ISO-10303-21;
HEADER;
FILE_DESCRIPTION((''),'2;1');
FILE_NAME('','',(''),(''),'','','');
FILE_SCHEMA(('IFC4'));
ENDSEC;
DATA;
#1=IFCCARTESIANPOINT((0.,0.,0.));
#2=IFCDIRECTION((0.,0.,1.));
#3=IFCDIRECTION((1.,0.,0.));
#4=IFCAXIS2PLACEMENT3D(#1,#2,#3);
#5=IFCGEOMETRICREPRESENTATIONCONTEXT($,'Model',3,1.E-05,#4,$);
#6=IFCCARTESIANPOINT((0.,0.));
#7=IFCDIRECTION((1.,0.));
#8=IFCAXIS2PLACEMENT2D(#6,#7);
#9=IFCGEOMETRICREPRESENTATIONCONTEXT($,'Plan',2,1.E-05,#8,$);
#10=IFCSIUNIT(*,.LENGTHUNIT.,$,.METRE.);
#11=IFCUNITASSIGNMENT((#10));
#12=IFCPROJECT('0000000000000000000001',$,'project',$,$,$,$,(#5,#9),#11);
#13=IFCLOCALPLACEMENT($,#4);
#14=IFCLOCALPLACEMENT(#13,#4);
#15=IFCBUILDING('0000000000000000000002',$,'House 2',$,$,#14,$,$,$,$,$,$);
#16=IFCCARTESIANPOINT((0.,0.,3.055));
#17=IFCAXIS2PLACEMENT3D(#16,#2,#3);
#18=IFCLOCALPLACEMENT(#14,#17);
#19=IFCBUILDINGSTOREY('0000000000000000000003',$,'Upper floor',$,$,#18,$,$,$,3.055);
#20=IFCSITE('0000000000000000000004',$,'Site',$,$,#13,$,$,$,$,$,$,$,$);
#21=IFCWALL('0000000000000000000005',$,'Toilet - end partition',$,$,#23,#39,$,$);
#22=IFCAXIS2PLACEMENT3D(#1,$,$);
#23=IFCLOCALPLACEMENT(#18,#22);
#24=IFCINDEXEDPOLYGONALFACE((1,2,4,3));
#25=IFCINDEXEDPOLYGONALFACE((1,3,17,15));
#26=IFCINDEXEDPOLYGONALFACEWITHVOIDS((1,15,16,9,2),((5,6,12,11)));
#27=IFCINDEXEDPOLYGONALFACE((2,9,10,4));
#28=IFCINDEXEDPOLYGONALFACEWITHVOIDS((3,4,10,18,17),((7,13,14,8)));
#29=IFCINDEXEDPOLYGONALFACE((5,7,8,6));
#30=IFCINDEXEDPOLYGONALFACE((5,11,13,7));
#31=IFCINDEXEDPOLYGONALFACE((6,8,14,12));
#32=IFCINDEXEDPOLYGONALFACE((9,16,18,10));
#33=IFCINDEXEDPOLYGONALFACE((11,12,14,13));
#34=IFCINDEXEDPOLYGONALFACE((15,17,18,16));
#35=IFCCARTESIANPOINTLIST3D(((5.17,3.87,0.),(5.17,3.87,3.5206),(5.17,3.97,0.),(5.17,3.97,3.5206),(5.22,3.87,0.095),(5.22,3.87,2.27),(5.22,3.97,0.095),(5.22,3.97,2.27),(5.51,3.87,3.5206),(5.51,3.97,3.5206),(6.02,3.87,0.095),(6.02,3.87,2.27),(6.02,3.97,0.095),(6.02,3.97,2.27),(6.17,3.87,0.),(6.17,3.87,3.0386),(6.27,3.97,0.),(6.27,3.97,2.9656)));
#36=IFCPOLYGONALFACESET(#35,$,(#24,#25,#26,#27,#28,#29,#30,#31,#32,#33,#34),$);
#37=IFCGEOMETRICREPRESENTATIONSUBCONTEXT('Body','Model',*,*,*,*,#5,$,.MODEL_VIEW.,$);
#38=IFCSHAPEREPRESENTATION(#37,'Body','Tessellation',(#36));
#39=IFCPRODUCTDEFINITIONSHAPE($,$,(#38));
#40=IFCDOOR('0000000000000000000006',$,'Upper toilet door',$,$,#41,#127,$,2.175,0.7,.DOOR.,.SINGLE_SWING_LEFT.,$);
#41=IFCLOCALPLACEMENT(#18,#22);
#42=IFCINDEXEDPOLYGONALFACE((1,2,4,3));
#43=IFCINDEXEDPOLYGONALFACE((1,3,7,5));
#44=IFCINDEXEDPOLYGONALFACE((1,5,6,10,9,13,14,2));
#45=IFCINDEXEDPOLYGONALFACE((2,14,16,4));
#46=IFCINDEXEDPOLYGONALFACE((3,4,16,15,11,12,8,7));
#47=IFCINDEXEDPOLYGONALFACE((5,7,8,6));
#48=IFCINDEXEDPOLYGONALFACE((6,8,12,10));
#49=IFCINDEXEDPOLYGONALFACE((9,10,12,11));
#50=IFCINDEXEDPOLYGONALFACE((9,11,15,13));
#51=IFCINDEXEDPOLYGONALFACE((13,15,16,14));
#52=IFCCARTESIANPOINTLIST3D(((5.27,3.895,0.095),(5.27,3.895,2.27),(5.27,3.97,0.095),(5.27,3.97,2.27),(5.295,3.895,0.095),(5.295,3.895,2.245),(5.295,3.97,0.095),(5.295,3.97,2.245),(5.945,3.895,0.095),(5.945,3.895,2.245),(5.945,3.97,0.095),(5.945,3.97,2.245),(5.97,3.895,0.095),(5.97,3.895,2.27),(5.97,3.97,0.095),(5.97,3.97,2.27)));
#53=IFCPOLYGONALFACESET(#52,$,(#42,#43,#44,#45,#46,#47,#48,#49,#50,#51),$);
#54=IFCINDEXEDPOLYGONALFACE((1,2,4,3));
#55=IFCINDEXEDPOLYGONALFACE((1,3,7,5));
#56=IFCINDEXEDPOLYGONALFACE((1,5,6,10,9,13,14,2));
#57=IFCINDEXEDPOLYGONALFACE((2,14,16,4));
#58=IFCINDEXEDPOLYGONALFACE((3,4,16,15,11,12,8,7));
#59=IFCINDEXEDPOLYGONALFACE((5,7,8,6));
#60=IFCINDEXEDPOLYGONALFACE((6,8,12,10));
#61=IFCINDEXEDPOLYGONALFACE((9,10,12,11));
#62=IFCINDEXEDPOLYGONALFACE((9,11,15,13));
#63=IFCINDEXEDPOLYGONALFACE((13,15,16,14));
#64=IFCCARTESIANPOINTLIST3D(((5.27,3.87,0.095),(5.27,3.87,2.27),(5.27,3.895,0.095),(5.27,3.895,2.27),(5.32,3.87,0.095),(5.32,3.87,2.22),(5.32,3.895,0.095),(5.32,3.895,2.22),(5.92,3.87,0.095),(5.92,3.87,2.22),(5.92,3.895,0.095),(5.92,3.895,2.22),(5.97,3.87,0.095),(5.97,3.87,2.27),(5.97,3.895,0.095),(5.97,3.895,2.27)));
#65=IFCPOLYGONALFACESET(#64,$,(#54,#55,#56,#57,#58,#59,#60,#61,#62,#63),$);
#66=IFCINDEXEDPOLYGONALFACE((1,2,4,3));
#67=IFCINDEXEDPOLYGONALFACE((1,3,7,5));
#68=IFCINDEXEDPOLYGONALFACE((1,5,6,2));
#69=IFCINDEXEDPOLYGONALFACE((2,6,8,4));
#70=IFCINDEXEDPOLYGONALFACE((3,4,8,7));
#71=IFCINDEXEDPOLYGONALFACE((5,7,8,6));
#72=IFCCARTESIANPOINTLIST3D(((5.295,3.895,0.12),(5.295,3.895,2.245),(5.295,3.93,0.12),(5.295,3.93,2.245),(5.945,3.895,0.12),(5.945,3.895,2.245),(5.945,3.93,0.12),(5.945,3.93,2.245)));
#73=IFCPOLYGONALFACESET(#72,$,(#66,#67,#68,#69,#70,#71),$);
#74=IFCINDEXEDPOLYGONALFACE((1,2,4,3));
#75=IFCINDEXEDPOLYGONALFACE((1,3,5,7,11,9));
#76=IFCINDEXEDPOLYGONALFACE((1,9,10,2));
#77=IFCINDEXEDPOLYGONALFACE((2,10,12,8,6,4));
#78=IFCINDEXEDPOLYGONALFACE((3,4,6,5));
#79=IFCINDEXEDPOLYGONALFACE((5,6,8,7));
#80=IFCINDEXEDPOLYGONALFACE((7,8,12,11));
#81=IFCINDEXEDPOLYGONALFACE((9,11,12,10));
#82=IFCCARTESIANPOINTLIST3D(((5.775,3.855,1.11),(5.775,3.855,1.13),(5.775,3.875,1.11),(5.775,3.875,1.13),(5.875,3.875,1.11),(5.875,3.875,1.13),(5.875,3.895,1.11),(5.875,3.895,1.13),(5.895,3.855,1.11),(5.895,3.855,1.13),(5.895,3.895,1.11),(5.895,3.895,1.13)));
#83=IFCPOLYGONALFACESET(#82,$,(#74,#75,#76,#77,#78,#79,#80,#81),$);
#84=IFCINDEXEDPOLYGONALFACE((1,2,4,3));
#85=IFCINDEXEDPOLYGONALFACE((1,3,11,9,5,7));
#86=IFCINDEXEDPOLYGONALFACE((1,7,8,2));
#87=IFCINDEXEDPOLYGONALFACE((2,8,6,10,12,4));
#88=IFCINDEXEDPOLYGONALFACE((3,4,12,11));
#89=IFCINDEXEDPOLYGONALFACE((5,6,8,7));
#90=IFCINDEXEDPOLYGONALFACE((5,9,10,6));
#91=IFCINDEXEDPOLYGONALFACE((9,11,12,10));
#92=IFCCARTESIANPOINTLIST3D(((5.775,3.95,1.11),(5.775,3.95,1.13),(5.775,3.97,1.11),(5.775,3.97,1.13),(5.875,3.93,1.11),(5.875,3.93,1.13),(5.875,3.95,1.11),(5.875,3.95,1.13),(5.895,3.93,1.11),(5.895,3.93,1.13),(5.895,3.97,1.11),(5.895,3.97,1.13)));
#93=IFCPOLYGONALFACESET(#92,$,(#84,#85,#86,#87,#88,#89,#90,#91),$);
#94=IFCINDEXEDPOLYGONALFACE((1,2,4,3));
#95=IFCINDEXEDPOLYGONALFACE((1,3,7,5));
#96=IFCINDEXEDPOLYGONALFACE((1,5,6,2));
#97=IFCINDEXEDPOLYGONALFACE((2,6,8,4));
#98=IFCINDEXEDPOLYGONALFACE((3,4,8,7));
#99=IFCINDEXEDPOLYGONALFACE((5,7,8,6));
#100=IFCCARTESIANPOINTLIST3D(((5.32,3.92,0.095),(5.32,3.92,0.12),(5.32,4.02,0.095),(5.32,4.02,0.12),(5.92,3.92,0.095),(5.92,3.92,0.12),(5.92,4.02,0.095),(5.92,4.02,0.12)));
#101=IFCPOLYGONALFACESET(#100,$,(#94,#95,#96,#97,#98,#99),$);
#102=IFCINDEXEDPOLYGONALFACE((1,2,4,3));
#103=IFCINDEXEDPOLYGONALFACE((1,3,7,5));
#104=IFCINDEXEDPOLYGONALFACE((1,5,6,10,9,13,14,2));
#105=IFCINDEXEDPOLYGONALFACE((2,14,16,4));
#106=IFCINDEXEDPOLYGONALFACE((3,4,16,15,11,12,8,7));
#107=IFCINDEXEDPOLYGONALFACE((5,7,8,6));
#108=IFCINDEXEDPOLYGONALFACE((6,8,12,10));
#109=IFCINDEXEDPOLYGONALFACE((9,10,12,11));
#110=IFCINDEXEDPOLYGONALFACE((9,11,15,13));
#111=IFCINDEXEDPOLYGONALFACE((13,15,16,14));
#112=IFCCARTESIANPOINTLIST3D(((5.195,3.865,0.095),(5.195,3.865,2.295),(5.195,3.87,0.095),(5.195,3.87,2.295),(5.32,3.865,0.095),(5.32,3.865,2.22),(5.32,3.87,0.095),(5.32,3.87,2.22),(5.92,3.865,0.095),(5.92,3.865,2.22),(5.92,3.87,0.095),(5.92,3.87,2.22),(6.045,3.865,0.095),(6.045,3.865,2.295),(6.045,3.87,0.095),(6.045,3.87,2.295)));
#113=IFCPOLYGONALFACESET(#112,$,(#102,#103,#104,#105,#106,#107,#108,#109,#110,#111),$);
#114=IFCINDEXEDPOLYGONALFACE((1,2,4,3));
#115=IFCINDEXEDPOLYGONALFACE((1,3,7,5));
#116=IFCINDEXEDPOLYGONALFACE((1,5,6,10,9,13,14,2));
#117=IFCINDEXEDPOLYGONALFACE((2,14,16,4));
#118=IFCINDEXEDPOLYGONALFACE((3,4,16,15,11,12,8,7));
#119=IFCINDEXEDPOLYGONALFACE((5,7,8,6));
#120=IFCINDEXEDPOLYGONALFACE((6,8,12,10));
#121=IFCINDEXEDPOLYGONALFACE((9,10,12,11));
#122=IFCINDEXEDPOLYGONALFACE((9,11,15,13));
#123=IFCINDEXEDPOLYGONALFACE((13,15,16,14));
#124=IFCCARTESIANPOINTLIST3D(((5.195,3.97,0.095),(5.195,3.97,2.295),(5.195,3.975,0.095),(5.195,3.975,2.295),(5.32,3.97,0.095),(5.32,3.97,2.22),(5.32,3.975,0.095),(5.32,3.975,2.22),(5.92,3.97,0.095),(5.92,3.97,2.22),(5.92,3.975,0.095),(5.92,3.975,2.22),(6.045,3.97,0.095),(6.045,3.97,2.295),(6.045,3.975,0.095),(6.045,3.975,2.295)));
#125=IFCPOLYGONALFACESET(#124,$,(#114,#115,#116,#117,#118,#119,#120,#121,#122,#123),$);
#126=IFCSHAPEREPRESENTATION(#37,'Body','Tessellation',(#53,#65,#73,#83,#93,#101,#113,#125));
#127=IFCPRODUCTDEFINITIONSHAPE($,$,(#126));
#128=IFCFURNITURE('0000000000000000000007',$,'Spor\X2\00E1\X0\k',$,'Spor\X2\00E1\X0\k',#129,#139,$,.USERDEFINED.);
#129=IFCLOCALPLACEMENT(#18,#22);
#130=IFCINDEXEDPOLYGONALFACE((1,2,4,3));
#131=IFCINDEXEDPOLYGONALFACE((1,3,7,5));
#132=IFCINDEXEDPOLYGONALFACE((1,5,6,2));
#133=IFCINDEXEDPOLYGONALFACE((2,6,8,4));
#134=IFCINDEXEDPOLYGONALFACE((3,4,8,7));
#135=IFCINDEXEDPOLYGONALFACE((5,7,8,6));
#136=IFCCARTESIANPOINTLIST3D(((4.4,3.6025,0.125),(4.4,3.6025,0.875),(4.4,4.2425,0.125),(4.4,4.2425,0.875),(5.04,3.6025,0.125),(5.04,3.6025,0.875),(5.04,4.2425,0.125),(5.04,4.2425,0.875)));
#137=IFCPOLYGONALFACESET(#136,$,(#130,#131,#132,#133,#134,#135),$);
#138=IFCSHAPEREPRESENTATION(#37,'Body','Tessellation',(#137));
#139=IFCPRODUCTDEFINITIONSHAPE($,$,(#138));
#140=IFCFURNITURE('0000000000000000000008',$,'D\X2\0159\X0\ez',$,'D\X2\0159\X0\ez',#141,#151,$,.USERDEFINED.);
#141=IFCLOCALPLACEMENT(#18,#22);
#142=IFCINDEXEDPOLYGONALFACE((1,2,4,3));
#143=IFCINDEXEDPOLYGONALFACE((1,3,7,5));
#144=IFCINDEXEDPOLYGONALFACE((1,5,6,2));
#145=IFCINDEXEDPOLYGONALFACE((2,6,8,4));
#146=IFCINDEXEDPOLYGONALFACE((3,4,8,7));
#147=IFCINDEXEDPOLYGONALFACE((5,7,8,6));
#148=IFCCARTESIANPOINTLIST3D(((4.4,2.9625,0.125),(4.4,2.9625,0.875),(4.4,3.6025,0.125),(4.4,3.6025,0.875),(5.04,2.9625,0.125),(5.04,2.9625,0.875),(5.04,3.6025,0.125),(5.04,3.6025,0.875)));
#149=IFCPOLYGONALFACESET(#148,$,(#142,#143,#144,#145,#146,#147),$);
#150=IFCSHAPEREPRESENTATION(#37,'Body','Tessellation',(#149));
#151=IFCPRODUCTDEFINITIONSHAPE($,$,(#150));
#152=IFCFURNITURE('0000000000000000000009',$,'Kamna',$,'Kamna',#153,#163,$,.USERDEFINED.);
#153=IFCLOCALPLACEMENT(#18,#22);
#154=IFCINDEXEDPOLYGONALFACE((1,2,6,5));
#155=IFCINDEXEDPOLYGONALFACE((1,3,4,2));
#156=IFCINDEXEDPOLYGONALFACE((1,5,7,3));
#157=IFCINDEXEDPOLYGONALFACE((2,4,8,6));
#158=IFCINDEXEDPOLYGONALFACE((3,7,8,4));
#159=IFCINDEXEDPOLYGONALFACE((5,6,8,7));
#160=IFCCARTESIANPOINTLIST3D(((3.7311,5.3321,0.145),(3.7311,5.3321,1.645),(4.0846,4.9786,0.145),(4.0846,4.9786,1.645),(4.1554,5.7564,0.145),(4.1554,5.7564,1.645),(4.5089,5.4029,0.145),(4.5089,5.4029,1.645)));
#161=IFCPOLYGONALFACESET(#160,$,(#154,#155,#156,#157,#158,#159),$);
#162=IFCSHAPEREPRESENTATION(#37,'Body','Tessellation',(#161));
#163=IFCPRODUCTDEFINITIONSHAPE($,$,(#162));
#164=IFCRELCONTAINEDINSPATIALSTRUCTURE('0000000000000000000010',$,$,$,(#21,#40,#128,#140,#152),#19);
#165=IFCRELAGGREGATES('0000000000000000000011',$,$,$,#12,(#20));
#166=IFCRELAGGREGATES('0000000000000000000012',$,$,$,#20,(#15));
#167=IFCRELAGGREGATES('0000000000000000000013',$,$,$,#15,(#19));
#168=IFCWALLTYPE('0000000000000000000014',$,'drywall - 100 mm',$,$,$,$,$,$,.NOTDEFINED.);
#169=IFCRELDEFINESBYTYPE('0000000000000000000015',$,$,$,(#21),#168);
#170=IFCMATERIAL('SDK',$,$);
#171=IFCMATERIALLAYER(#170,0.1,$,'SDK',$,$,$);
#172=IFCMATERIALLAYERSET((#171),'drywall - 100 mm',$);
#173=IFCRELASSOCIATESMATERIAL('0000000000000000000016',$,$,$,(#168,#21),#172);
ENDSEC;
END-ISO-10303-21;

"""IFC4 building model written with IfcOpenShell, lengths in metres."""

from ifc_helpers import new_model, entity, si_unit, frame, origin_with_axes, origin_2d_with_axis, place, context, subcontext, project, spatial, line, indexed_curve, outline, extrude, clip, halfspace, shape, source, transform, mapped, material, layer, layer_set, layer_usage, type_object, element, fill, save


model = new_model("IFC4")

# Units and contexts
model_context = context("Model", 3, precision=1e-05, world=origin_with_axes())
plan_context = context("Plan", 2, precision=1e-05, world=origin_2d_with_axis())
body_context_1 = subcontext(model_context, "Body", "Model", "MODEL_VIEW")
body_context_2 = subcontext(plan_context, "Body", "Plan", "PLAN_VIEW")
ifc_project = project(units=[si_unit("LENGTHUNIT", "METRE")], contexts=[model_context, plan_context])

# Site, building, storey
site_placement = place(None, origin_with_axes())
site = spatial("IfcSite", under=ifc_project, at=site_placement, Name="Site")
building_placement = place(site_placement, origin_with_axes())
building = spatial("IfcBuilding", under=site, at=building_placement, Name="House 2")
storey_placement = place(building_placement, frame((0.0, 0.0, 3.055), z_axis=(0.0, 0.0, 1.0), x_axis=(1.0, 0.0, 0.0)))
storey = spatial("IfcBuildingStorey", under=building, at=storey_placement, Name="Upper floor", Elevation=3.055)

# Shared definitions
ifc_material_1 = material(Name="SDK")
ifc_layer = layer(ifc_material_1, 0.1, Name="SDK")
ifc_layer_set = layer_set([ifc_layer], Name="drywall - 100 mm")
wall_type = type_object("IfcWallType", Name="drywall - 100 mm", PredefinedType="NOTDEFINED", material=ifc_layer_set)

# Wall, opening, door
ifc_layer_usage_1 = layer_usage(ifc_layer_set, "AXIS2", "NEGATIVE", 0.05)
wall_1_placement = place(storey_placement, frame((5.17, 3.92, 0.0), z_axis=(0.0, 0.0, 1.0), x_axis=(1.0, 0.0, 0.0)))
wall_1 = element("IfcWall", 1, at=wall_1_placement, inside=storey, type_object=wall_type, material=ifc_layer_usage_1, Name="Toilet - end partition", context=body_context_1, shape_type="Clipping", body=[
    clip(clip(clip(extrude(outline(indexed_curve([(0.0, -0.05), (0.0, 0.05), (1.1, 0.05), (1.0, -0.05)], segments=[line(1, 2, 3, 4, 1)])), origin_with_axes(), (0.0, 0.0, 1.0), 4.9457), halfspace(frame((-4.9413, -3.92, 1.3216), z_axis=(-0.58975, 0.0, 0.807586), x_axis=(0.0, 1.0, 0.0)), False)), halfspace(frame((3.3513, -3.92, 1.3216), z_axis=(0.58975, 0.0, 0.807586), x_axis=(0.0, -1.0, 0.0)), False)), halfspace(frame((-5.17, -3.92, 3.5206), z_axis=(0.0, 0.0, 1.0), x_axis=(-1.0, 0.0, 0.0)), False)),
])
opening_1_placement = place(wall_1_placement, frame((0.05, 0.0, 0.095), z_axis=(0.0, 0.0, 1.0), x_axis=(1.0, 0.0, 0.0)))
opening_1 = element("IfcOpeningElement", 2, at=opening_1_placement, cuts=wall_1, PredefinedType="OPENING", context=body_context_1, shape_type="SweptSolid", body=[
    extrude(outline(indexed_curve([(0.0, 0.0), (0.0, 0.2), (0.8, 0.2), (0.8, 0.0), (0.0, 0.0)], self_intersect=False)), frame((0.0, -0.1, 0.0), z_axis=(0.0, 0.0, 1.0), x_axis=(1.0, 0.0, 0.0)), (0.0, 0.0, 1.0), 2.175),
])
shared_indexed_poly_curve = entity("IfcIndexedPolyCurve", entity("IfcCartesianPointList2D", [[-0.075, 0.0], [-0.075, 2.2], [0.775, 2.2], [0.775, 0.0], [0.65, 0.0], [0.65, 2.125], [0.05, 2.125], [0.05, 0.0]]), [entity("IfcLineIndex", [1, 2, 3, 4, 5, 6, 7, 8, 1])])
shared_shape = source(origin_with_axes(), body_context_2, "Body", "Curve2D", [
    entity("IfcIndexedPolyCurve", entity("IfcCartesianPointList2D", [[0.0, -0.05], [0.0, 0.05], [0.025, 0.05], [0.025, -0.025], [0.05, -0.025], [0.05, -0.05]]), [entity("IfcLineIndex", [1, 2, 3, 4, 5, 6, 1])]),
    entity("IfcIndexedPolyCurve", entity("IfcCartesianPointList2D", [[0.7, -0.05], [0.7, 0.05], [0.675, 0.05], [0.675, -0.025], [0.65, -0.025], [0.65, -0.05]]), [entity("IfcLineIndex", [1, 2, 3, 4, 5, 6, 1])]),
    entity("IfcTrimmedCurve", entity("IfcEllipse", entity("IfcAxis2Placement2D", entity("IfcCartesianPoint", [0.06, 0.05]), entity("IfcDirection", [1.0, 0.0])), 0.615, 0.65), [entity("IfcCartesianPoint", [0.675, 0.05])], [entity("IfcCartesianPoint", [0.06, 0.7])], True, "CARTESIAN"),
    entity("IfcIndexedPolyCurve", entity("IfcCartesianPointList2D", [[0.025, 0.05], [0.06, 0.05], [0.06, 0.7], [0.025, 0.7]]), [entity("IfcLineIndex", [1, 2, 3, 4, 1])]),
])
door_placement = place(opening_1_placement, frame((0.05, 0.0, 0.0), z_axis=(0.0, 0.0, 1.0), x_axis=(1.0, 0.0, 0.0)))
door = element("IfcDoor", 3, at=door_placement, inside=storey, Name="Upper toilet door", OperationType="SINGLE_SWING_LEFT", OverallHeight=2.175, OverallWidth=0.7, PredefinedType="DOOR", shapes=[
    shape(body_context_1, "Body", "SweptSolid", [extrude(outline(indexed_curve([(0.0, 0.0), (0.0, 2.175), (0.7, 2.175), (0.7, 0.0), (0.675, 0.0), (0.675, 2.15), (0.025, 2.15), (0.025, 0.0)], segments=[line(1, 2, 3, 4, 5, 6, 7, 8, 1)])), frame((0.0, -0.025, 0.0), z_axis=(0.0, -1.0, 0.0), x_axis=(1.0, 0.0, 0.0)), (0.0, 0.0, -1.0), 0.075), extrude(outline(indexed_curve([(0.0, 0.0), (0.0, 2.175), (0.7, 2.175), (0.7, 0.0), (0.65, 0.0), (0.65, 2.125), (0.05, 2.125), (0.05, 0.0)], segments=[line(1, 2, 3, 4, 5, 6, 7, 8, 1)])), frame((0.0, -0.05, 0.0), z_axis=(0.0, -1.0, 0.0), x_axis=(1.0, 0.0, 0.0)), (0.0, 0.0, -1.0), 0.025), extrude(outline(indexed_curve([(0.0, 0.0), (0.65, 0.0), (0.65, 0.035), (0.0, 0.035)], segments=[line(1, 2, 3, 4, 1)])), frame((0.025, -0.025, 0.025), z_axis=(0.0, 0.0, 1.0), x_axis=(1.0, 0.0, 0.0)), (0.0, 0.0, 1.0), 2.125), extrude(outline(indexed_curve([(0.0, 0.0), (0.0, -0.04), (-0.12, -0.04), (-0.12, -0.02), (-0.02, -0.02), (-0.02, 0.0)], segments=[line(1, 2, 3, 4, 5, 6, 1)])), frame((0.625, -0.025, 1.015), z_axis=(0.0, 0.0, 1.0), x_axis=(1.0, 0.0, 0.0)), (0.0, 0.0, 1.0), 0.02), extrude(outline(indexed_curve([(0.0, 0.0), (0.0, 0.04), (-0.12, 0.04), (-0.12, 0.02), (-0.02, 0.02), (-0.02, 0.0)], segments=[line(1, 2, 3, 4, 5, 6, 1)])), frame((0.625, 0.01, 1.015), z_axis=(0.0, 0.0, 1.0), x_axis=(1.0, 0.0, 0.0)), (0.0, 0.0, 1.0), 0.02), extrude(outline(indexed_curve([(0.0, 0.0), (0.6, 0.0), (0.6, 0.1), (0.0, 0.1)], segments=[line(1, 2, 3, 4, 1)])), frame((0.05, 0.0, 0.0), z_axis=(0.0, 0.0, 1.0), x_axis=(1.0, 0.0, 0.0)), (0.0, 0.0, 1.0), 0.025), entity("IfcExtrudedAreaSolid", entity("IfcArbitraryClosedProfileDef", "AREA", None, shared_indexed_poly_curve), entity("IfcAxis2Placement3D", entity("IfcCartesianPoint", [0.0, -0.055, 0.0]), entity("IfcDirection", [0.0, -1.0, 0.0]), entity("IfcDirection", [1.0, 0.0, 0.0])), entity("IfcDirection", [0.0, 0.0, -1.0]), 0.005), entity("IfcExtrudedAreaSolid", entity("IfcArbitraryClosedProfileDef", "AREA", None, shared_indexed_poly_curve), entity("IfcAxis2Placement3D", entity("IfcCartesianPoint", [0.0, 0.05, 0.0]), entity("IfcDirection", [0.0, -1.0, 0.0]), entity("IfcDirection", [1.0, 0.0, 0.0])), entity("IfcDirection", [0.0, 0.0, -1.0]), 0.005)]),
    shape(body_context_2, "Body", "MappedRepresentation", [mapped(shared_shape, transform((0.0, 0.0, 1.0875), x_axis=(1.0, 0.0, 0.0), y_axis=(0.0, 1.0, 0.0), z_axis=(0.0, 0.0, 1.0), scale=1.0))]),
])
fill(opening_1, door)

# Furniture
furniture_1_placement = place(storey_placement, frame((4.72, 3.9225, 0.125), z_axis=(0.0, 0.0, 1.0), x_axis=(1.0, 0.0, 0.0)))
element("IfcFurniture", 4, at=furniture_1_placement, inside=storey, Name="Sporák", ObjectType="Sporák", PredefinedType="USERDEFINED", shapes=[
    shape(body_context_1, "Body", "SweptSolid", [extrude(outline(indexed_curve([(-0.32, -0.32), (0.32, -0.32), (0.32, 0.32), (-0.32, 0.32)])), None, (0.0, 0.0, 1.0), 0.75)]),
    shape(body_context_2, "Body", "Curve2D", [entity("IfcIndexedPolyCurve", entity("IfcCartesianPointList2D", [[-0.32, -0.32], [0.32, -0.32], [0.32, 0.32], [-0.32, 0.32], [-0.32, -0.32]]), None, False)]),
])
furniture_2_placement = place(storey_placement, frame((4.72, 3.2825, 0.125), z_axis=(0.0, 0.0, 1.0), x_axis=(1.0, 0.0, 0.0)))
element("IfcFurniture", 5, at=furniture_2_placement, inside=storey, Name="Dřez", ObjectType="Dřez", PredefinedType="USERDEFINED", shapes=[
    shape(body_context_1, "Body", "SweptSolid", [extrude(outline(indexed_curve([(-0.32, -0.32), (0.32, -0.32), (0.32, 0.32), (-0.32, 0.32)])), None, (0.0, 0.0, 1.0), 0.75)]),
    shape(body_context_2, "Body", "Curve2D", [entity("IfcIndexedPolyCurve", entity("IfcCartesianPointList2D", [[-0.32, -0.32], [0.32, -0.32], [0.32, 0.32], [-0.32, 0.32], [-0.32, -0.32]]), None, False)]),
])
furniture_3_placement = place(storey_placement, frame((4.12, 5.3675, 0.145), z_axis=(0.0, 0.0, 1.0), x_axis=(0.707107, 0.707107, 0.0)))
element("IfcFurniture", 6, at=furniture_3_placement, inside=storey, Name="Kamna", ObjectType="Kamna", PredefinedType="USERDEFINED", shapes=[
    shape(body_context_1, "Body", "SweptSolid", [extrude(outline(indexed_curve([(-0.3, -0.25), (0.3, -0.25), (0.3, 0.25), (-0.3, 0.25)])), None, (0.0, 0.0, 1.0), 1.5)]),
    shape(body_context_2, "Body", "Curve2D", [entity("IfcIndexedPolyCurve", entity("IfcCartesianPointList2D", [[-0.3, -0.25], [0.3, -0.25], [0.3, 0.25], [-0.3, 0.25], [-0.3, -0.25]]), None, False)]),
])

save(model, "model.ifc")
